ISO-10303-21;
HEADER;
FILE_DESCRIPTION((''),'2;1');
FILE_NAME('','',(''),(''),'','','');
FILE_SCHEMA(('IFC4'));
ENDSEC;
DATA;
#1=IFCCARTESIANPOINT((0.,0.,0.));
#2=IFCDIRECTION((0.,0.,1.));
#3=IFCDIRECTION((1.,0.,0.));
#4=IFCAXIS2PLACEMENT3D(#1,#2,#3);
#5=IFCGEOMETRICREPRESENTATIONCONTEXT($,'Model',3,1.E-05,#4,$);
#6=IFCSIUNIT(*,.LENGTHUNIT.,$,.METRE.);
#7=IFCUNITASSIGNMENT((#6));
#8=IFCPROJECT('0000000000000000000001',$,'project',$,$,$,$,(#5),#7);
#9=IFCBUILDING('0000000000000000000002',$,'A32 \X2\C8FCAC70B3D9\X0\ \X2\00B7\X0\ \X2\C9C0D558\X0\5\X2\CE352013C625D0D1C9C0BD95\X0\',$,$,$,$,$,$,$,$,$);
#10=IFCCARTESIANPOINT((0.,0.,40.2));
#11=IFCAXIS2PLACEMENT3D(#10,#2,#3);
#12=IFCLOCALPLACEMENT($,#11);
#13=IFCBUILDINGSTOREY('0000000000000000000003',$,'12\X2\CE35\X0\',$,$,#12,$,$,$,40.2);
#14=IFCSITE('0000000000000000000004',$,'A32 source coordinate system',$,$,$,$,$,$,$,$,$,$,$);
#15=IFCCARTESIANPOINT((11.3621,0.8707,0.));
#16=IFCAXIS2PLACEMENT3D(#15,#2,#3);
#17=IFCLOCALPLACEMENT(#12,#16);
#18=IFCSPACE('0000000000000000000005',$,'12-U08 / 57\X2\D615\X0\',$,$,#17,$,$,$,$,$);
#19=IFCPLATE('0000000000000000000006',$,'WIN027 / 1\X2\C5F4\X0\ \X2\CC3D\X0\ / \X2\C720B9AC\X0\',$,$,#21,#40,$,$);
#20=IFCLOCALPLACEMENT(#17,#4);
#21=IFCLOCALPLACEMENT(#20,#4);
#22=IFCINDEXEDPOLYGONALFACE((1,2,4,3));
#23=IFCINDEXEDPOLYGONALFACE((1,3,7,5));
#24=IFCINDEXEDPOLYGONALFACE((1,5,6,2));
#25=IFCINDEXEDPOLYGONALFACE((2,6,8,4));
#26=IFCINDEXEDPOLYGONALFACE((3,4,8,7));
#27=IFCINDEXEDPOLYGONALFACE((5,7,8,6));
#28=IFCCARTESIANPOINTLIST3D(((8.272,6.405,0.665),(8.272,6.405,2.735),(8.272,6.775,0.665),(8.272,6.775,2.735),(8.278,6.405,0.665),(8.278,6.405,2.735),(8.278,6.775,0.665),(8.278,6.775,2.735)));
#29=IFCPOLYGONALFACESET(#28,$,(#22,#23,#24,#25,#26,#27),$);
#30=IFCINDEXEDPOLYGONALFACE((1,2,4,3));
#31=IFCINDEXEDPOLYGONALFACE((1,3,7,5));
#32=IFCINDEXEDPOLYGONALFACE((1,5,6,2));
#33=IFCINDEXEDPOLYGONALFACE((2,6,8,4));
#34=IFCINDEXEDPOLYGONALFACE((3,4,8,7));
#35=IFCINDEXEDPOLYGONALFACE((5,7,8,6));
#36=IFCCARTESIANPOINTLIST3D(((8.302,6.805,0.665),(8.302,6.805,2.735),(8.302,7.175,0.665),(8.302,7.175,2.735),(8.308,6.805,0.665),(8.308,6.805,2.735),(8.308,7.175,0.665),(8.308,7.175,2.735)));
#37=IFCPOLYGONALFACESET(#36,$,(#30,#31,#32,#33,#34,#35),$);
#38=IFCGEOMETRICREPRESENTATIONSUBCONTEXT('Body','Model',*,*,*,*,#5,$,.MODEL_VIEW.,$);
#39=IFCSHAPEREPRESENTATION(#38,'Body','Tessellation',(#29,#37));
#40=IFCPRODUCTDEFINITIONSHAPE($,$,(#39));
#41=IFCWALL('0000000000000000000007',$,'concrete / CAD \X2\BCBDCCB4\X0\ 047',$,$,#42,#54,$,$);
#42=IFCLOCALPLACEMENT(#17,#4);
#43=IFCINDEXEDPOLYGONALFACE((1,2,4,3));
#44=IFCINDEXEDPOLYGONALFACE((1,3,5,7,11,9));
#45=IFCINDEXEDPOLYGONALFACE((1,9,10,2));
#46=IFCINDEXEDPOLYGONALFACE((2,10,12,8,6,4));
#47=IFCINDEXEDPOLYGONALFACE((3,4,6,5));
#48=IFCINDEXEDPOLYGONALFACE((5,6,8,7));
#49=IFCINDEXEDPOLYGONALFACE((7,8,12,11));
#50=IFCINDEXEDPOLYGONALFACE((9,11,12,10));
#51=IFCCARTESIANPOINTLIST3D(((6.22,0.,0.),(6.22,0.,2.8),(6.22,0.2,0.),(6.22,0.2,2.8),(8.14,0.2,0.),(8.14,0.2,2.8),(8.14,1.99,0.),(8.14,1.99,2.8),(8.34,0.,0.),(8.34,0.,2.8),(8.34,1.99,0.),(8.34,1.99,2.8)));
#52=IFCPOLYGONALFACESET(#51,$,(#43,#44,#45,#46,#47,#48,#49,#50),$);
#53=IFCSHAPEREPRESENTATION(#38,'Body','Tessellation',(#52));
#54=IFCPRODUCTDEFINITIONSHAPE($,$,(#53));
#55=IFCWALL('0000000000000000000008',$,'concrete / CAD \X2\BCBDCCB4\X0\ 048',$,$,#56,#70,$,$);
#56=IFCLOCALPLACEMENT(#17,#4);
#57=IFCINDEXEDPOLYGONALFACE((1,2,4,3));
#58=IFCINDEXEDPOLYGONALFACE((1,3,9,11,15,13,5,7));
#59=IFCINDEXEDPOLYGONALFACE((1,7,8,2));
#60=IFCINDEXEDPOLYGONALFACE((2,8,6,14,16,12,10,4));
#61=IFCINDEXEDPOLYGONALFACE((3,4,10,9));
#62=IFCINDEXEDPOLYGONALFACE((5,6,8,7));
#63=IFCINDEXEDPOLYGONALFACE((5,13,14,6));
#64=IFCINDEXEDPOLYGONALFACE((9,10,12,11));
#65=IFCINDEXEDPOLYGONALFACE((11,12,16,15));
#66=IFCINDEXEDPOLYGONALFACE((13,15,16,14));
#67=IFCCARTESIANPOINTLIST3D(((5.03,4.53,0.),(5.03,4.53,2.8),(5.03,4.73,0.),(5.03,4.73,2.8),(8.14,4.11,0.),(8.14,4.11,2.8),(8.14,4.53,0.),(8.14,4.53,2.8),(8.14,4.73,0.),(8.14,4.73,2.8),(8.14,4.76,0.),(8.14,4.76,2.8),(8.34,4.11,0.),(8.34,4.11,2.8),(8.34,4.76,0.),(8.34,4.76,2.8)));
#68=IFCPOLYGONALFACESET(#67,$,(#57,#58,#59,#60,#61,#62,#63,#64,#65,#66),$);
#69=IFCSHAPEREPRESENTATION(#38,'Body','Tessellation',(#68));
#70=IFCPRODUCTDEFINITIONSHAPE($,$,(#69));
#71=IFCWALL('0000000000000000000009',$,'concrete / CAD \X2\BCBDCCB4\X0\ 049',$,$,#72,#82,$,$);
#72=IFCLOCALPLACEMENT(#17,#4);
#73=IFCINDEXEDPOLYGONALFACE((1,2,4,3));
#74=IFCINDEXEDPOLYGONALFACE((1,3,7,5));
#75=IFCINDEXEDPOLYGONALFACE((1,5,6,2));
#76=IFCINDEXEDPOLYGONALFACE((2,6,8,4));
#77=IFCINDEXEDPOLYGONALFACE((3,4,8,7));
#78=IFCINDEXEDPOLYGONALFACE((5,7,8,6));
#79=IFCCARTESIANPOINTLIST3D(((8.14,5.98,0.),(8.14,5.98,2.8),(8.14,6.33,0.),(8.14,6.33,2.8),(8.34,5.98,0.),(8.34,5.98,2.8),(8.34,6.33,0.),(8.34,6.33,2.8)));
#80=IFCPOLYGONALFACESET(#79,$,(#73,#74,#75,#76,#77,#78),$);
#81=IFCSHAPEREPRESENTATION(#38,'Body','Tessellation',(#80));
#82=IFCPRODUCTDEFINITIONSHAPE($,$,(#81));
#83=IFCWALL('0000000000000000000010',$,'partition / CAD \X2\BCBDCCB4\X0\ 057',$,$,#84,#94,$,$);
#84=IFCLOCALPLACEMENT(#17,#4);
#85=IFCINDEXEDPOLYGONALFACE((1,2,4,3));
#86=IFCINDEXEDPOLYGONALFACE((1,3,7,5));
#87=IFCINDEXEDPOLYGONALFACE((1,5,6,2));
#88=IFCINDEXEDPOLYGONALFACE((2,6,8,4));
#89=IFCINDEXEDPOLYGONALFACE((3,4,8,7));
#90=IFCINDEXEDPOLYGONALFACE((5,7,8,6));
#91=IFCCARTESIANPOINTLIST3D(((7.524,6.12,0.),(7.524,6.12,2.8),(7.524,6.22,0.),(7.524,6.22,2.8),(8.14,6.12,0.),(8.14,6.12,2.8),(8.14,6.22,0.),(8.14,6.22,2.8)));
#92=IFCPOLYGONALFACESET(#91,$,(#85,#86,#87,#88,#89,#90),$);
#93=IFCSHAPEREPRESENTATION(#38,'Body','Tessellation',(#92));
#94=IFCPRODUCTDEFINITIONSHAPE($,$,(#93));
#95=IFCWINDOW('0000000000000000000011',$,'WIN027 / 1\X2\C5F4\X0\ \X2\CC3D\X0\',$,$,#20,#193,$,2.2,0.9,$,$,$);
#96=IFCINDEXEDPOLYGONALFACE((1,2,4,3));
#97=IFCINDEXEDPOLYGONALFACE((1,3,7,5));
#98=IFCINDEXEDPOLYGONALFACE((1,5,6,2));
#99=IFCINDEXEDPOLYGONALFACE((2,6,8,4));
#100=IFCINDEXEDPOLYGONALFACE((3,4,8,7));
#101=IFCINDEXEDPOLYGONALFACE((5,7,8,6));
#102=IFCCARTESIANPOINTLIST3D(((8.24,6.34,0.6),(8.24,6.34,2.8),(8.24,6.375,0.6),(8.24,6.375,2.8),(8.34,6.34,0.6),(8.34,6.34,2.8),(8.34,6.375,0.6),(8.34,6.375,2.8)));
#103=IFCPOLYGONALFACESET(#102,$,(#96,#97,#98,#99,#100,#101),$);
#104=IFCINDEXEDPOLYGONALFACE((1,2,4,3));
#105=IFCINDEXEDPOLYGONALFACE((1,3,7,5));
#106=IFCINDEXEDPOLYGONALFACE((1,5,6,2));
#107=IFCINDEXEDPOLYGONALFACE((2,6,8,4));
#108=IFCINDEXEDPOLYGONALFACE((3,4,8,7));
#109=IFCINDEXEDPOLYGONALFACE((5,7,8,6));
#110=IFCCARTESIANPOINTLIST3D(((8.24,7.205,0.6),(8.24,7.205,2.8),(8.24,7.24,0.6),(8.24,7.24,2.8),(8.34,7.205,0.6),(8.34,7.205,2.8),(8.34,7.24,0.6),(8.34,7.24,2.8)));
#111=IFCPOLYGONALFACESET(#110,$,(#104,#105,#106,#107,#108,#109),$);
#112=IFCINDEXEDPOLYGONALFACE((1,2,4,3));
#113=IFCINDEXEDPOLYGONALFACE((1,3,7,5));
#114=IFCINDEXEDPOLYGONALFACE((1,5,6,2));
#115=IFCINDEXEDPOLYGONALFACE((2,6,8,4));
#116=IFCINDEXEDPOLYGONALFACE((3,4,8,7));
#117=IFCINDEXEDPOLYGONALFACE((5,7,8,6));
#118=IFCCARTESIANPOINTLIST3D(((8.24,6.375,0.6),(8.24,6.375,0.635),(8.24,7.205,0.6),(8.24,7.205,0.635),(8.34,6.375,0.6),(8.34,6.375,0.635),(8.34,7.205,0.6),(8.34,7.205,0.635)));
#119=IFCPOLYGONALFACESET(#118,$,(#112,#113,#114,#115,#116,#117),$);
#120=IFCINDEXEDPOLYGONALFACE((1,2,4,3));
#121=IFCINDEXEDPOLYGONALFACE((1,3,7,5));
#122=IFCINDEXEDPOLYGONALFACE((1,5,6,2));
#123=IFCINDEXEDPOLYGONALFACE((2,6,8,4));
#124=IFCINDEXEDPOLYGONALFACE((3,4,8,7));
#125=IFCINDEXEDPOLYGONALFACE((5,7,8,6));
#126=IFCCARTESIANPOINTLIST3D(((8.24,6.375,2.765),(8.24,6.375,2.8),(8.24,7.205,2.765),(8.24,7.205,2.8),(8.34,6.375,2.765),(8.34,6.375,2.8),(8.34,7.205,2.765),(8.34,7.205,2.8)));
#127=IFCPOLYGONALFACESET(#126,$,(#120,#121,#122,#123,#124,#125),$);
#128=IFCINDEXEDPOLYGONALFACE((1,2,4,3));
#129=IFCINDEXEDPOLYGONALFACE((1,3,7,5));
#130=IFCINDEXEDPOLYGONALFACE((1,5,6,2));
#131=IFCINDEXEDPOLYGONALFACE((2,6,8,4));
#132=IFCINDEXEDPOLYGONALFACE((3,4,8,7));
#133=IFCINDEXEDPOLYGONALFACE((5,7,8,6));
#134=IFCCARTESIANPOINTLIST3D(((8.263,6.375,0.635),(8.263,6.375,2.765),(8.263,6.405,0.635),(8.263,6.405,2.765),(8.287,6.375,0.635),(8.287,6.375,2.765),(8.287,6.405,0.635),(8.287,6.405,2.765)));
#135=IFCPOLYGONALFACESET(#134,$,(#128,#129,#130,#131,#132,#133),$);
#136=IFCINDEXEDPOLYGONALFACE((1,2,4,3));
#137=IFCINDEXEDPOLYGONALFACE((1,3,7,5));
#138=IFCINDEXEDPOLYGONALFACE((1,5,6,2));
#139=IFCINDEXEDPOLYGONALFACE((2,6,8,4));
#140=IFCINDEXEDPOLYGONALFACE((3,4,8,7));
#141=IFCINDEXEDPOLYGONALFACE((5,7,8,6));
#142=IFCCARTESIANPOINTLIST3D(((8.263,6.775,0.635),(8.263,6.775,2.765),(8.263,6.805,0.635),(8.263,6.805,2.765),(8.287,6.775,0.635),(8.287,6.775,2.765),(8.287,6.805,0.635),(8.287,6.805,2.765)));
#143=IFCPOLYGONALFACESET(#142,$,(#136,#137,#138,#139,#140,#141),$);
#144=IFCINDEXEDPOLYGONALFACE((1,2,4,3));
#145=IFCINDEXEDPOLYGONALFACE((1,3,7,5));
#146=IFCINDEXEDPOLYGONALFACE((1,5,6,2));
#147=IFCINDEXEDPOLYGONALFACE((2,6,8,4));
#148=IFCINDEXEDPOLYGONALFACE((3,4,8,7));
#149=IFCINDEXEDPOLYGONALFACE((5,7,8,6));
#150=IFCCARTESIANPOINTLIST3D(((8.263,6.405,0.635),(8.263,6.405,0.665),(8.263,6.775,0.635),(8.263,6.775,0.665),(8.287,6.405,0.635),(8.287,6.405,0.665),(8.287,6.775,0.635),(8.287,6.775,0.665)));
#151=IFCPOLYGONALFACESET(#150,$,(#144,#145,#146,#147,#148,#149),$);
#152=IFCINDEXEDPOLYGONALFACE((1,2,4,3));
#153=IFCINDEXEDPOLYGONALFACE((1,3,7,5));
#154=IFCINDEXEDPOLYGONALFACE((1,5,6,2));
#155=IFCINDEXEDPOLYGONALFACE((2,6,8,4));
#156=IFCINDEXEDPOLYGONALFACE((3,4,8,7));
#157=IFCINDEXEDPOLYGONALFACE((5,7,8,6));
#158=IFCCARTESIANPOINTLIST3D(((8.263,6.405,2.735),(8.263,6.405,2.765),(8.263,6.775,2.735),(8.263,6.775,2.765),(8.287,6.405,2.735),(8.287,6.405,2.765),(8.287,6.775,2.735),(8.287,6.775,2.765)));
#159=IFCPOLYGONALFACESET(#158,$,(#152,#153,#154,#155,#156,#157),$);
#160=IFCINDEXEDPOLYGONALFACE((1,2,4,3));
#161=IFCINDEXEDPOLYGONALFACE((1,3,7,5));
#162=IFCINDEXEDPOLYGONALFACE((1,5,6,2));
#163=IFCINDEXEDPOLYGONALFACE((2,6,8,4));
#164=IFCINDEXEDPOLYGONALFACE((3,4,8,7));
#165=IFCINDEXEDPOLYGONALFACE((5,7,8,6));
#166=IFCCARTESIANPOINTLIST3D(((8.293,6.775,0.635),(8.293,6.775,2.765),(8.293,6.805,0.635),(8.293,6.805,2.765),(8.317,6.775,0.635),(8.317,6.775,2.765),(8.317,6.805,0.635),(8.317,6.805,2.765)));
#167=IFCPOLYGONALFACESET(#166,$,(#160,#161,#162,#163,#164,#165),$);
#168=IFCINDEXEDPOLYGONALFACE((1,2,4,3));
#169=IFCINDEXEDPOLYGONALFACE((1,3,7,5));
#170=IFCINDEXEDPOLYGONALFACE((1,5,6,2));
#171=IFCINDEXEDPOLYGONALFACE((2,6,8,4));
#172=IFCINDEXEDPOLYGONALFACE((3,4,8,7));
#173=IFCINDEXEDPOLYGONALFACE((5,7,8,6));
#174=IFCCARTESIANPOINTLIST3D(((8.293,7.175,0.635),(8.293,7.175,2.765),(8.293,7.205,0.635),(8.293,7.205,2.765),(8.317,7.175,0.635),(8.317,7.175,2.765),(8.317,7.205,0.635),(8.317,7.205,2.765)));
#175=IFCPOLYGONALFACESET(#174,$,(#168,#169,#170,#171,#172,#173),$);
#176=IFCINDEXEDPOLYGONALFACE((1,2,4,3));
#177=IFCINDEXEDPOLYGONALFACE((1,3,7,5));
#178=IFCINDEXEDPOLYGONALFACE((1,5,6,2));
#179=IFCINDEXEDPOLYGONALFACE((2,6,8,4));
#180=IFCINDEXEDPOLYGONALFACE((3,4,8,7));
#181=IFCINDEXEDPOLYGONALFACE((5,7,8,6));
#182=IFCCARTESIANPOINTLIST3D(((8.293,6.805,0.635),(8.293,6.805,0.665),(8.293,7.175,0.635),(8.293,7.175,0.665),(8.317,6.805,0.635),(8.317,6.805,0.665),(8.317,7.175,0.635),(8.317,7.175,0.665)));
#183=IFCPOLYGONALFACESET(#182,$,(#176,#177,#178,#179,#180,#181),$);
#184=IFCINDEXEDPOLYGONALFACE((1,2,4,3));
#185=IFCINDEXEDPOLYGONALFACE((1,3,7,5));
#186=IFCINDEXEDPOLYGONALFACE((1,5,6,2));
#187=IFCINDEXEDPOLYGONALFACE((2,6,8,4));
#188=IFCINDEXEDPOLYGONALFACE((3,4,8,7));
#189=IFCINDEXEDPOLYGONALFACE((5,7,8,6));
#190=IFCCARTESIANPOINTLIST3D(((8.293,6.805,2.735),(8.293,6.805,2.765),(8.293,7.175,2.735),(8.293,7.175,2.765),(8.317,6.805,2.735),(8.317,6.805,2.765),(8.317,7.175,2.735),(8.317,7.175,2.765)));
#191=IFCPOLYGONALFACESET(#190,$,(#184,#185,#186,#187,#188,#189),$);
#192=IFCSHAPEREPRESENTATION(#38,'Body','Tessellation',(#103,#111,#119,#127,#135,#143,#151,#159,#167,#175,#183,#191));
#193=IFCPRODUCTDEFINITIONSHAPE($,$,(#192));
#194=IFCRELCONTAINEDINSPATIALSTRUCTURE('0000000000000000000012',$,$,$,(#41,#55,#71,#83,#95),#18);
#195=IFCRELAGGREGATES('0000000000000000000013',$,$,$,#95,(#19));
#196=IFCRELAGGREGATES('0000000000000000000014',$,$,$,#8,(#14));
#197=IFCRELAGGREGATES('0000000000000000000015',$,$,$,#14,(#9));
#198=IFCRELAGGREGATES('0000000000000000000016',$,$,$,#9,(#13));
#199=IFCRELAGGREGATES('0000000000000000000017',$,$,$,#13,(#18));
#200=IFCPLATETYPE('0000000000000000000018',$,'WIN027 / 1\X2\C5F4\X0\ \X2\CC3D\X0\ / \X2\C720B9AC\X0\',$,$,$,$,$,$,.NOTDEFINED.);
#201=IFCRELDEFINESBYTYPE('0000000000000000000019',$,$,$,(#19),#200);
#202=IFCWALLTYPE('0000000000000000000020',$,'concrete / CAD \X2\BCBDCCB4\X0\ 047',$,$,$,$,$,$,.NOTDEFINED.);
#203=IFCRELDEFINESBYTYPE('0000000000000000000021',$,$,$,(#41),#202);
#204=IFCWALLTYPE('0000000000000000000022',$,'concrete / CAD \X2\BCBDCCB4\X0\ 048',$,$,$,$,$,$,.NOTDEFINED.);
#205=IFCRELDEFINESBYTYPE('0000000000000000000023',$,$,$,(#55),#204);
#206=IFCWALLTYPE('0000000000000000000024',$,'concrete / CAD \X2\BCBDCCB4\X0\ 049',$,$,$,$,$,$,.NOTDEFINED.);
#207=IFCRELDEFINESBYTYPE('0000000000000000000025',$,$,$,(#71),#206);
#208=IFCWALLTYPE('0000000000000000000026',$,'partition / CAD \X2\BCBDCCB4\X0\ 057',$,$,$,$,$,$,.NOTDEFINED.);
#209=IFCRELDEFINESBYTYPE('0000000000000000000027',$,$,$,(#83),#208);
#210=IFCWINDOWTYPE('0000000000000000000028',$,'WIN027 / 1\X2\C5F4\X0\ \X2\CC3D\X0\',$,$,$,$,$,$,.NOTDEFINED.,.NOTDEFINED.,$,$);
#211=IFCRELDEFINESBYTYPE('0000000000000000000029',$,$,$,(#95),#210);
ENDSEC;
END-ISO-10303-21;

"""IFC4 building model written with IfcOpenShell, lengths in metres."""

from ifc_helpers import new_model, si_unit, frame, origin, origin_with_axes, place, context, subcontext, project, spatial, polyline, outline, extrude, source, transform, mapped, type_object, type_shapes, element, aggregate, save


model = new_model("IFC4")

# Units and contexts
model_context = context("Model", 3, precision=1e-05, world=origin_with_axes())
body_context = subcontext(model_context, "Body", "Model", "MODEL_VIEW")
ifc_project = project(units=[si_unit("LENGTHUNIT", "METRE")], contexts=[model_context])

# Plate
storey_placement = place(None, frame((0.0, 0.0, 40.2), z_axis=(0.0, 0.0, 1.0), x_axis=(1.0, 0.0, 0.0)))
space_placement = place(storey_placement, frame((11.3621, 0.8707, 0.0), z_axis=(0.0, 0.0, 1.0), x_axis=(1.0, 0.0, 0.0)))
plate_type_1 = type_object("IfcPlateType", Name="WIN027 / 1열 창 / 유리", PredefinedType="NOTDEFINED")
shared_shape_1 = source(origin(), body_context, "Body", "SweptSolid", [
    extrude(outline(polyline([(8.272, 6.405), (8.272, 6.775), (8.278, 6.775), (8.278, 6.405), (8.272, 6.405)])), frame((0.0, 0.0, 0.665)), (0.0, 0.0, 1.0), 2.07),
    extrude(outline(polyline([(8.302, 6.805), (8.302, 7.175), (8.308, 7.175), (8.308, 6.805), (8.302, 6.805)])), frame((0.0, 0.0, 0.665)), (0.0, 0.0, 1.0), 2.07),
])
type_shapes(plate_type_1, [shared_shape_1])
window_1_placement = place(space_placement, origin_with_axes())
plate_1_placement = place(window_1_placement, origin_with_axes())
plate_1 = element("IfcPlate", 1, at=plate_1_placement, type_object=plate_type_1, Name="WIN027 / 1열 창 / 유리", context=body_context, shape_type="MappedRepresentation", body=[
    mapped(shared_shape_1, transform((0.0, 0.0, 0.0), scale=1.0)),
])

# Site, building, storey, space
site = spatial("IfcSite", under=ifc_project, Name="A32 source coordinate system")
building = spatial("IfcBuilding", under=site, Name="A32 주거동 · 지하5층–옥탑지붕")
storey = spatial("IfcBuildingStorey", under=building, at=storey_placement, Name="12층", Elevation=40.2)
space = spatial("IfcSpace", under=storey, at=space_placement, Name="12-U08 / 57형")

# Walls
wall_type_1 = type_object("IfcWallType", Name="concrete / CAD 벽체 047", PredefinedType="NOTDEFINED")
shared_shape_2 = source(origin(), body_context, "Body", "SweptSolid", [
    extrude(outline(polyline([(8.14, 1.99), (8.34, 1.99), (8.34, 0.0), (6.22, 0.0), (6.22, 0.2), (8.14, 0.2), (8.14, 1.99)])), origin(), (0.0, 0.0, 1.0), 2.8),
])
type_shapes(wall_type_1, [shared_shape_2])
wall_1_placement = place(space_placement, origin_with_axes())
element("IfcWall", 2, at=wall_1_placement, inside=space, type_object=wall_type_1, Name="concrete / CAD 벽체 047", context=body_context, shape_type="MappedRepresentation", body=[
    mapped(shared_shape_2, transform((0.0, 0.0, 0.0), scale=1.0)),
])
wall_type_2 = type_object("IfcWallType", Name="concrete / CAD 벽체 048", PredefinedType="NOTDEFINED")
shared_shape_3 = source(origin(), body_context, "Body", "SweptSolid", [
    extrude(outline(polyline([(8.14, 4.53), (5.03, 4.53), (5.03, 4.73), (8.14, 4.73), (8.14, 4.76), (8.34, 4.76), (8.34, 4.11), (8.14, 4.11), (8.14, 4.53)])), origin(), (0.0, 0.0, 1.0), 2.8),
])
type_shapes(wall_type_2, [shared_shape_3])
wall_2_placement = place(space_placement, origin_with_axes())
element("IfcWall", 3, at=wall_2_placement, inside=space, type_object=wall_type_2, Name="concrete / CAD 벽체 048", context=body_context, shape_type="MappedRepresentation", body=[
    mapped(shared_shape_3, transform((0.0, 0.0, 0.0), scale=1.0)),
])
wall_type_3 = type_object("IfcWallType", Name="concrete / CAD 벽체 049", PredefinedType="NOTDEFINED")
shared_shape_4 = source(origin(), body_context, "Body", "SweptSolid", [
    extrude(outline(polyline([(8.34, 6.33), (8.34, 5.98), (8.14, 5.98), (8.14, 6.33), (8.34, 6.33)])), origin(), (0.0, 0.0, 1.0), 2.8),
])
type_shapes(wall_type_3, [shared_shape_4])
wall_3_placement = place(space_placement, origin_with_axes())
element("IfcWall", 4, at=wall_3_placement, inside=space, type_object=wall_type_3, Name="concrete / CAD 벽체 049", context=body_context, shape_type="MappedRepresentation", body=[
    mapped(shared_shape_4, transform((0.0, 0.0, 0.0), scale=1.0)),
])
wall_type_4 = type_object("IfcWallType", Name="partition / CAD 벽체 057", PredefinedType="NOTDEFINED")
shared_shape_5 = source(origin(), body_context, "Body", "SweptSolid", [
    extrude(outline(polyline([(7.524, 6.22), (8.14, 6.22), (8.14, 6.12), (7.524, 6.12), (7.524, 6.22)])), origin(), (0.0, 0.0, 1.0), 2.8),
])
type_shapes(wall_type_4, [shared_shape_5])
wall_4_placement = place(space_placement, origin_with_axes())
element("IfcWall", 5, at=wall_4_placement, inside=space, type_object=wall_type_4, Name="partition / CAD 벽체 057", context=body_context, shape_type="MappedRepresentation", body=[
    mapped(shared_shape_5, transform((0.0, 0.0, 0.0), scale=1.0)),
])

# Window
window_type_1 = type_object("IfcWindowType", Name="WIN027 / 1열 창", PartitioningType="NOTDEFINED", PredefinedType="NOTDEFINED")
shared_shape_6 = source(origin(), body_context, "Body", "SweptSolid", [
    extrude(outline(polyline([(8.24, 6.34), (8.24, 6.375), (8.34, 6.375), (8.34, 6.34), (8.24, 6.34)])), frame((0.0, 0.0, 0.6)), (0.0, 0.0, 1.0), 2.2),
    extrude(outline(polyline([(8.24, 7.205), (8.24, 7.24), (8.34, 7.24), (8.34, 7.205), (8.24, 7.205)])), frame((0.0, 0.0, 0.6)), (0.0, 0.0, 1.0), 2.2),
    extrude(outline(polyline([(8.24, 6.375), (8.24, 7.205), (8.34, 7.205), (8.34, 6.375), (8.24, 6.375)])), frame((0.0, 0.0, 0.6)), (0.0, 0.0, 1.0), 0.035),
    extrude(outline(polyline([(8.24, 6.375), (8.24, 7.205), (8.34, 7.205), (8.34, 6.375), (8.24, 6.375)])), frame((0.0, 0.0, 2.765)), (0.0, 0.0, 1.0), 0.035),
    extrude(outline(polyline([(8.263, 6.375), (8.263, 6.405), (8.287, 6.405), (8.287, 6.375), (8.263, 6.375)])), frame((0.0, 0.0, 0.635)), (0.0, 0.0, 1.0), 2.13),
    extrude(outline(polyline([(8.263, 6.775), (8.263, 6.805), (8.287, 6.805), (8.287, 6.775), (8.263, 6.775)])), frame((0.0, 0.0, 0.635)), (0.0, 0.0, 1.0), 2.13),
    extrude(outline(polyline([(8.263, 6.405), (8.263, 6.775), (8.287, 6.775), (8.287, 6.405), (8.263, 6.405)])), frame((0.0, 0.0, 0.635)), (0.0, 0.0, 1.0), 0.03),
    extrude(outline(polyline([(8.263, 6.405), (8.263, 6.775), (8.287, 6.775), (8.287, 6.405), (8.263, 6.405)])), frame((0.0, 0.0, 2.735)), (0.0, 0.0, 1.0), 0.03),
    extrude(outline(polyline([(8.293, 6.775), (8.293, 6.805), (8.317, 6.805), (8.317, 6.775), (8.293, 6.775)])), frame((0.0, 0.0, 0.635)), (0.0, 0.0, 1.0), 2.13),
    extrude(outline(polyline([(8.293, 7.175), (8.293, 7.205), (8.317, 7.205), (8.317, 7.175), (8.293, 7.175)])), frame((0.0, 0.0, 0.635)), (0.0, 0.0, 1.0), 2.13),
    extrude(outline(polyline([(8.293, 6.805), (8.293, 7.175), (8.317, 7.175), (8.317, 6.805), (8.293, 6.805)])), frame((0.0, 0.0, 0.635)), (0.0, 0.0, 1.0), 0.03),
    extrude(outline(polyline([(8.293, 6.805), (8.293, 7.175), (8.317, 7.175), (8.317, 6.805), (8.293, 6.805)])), frame((0.0, 0.0, 2.735)), (0.0, 0.0, 1.0), 0.03),
])
type_shapes(window_type_1, [shared_shape_6])
window_1 = element("IfcWindow", 6, at=window_1_placement, inside=space, type_object=window_type_1, Name="WIN027 / 1열 창", OverallHeight=2.2, OverallWidth=0.9, context=body_context, shape_type="MappedRepresentation", body=[
    mapped(shared_shape_6, transform((0.0, 0.0, 0.0), scale=1.0)),
])
aggregate(window_1, [plate_1])

save(model, "model.ifc")
